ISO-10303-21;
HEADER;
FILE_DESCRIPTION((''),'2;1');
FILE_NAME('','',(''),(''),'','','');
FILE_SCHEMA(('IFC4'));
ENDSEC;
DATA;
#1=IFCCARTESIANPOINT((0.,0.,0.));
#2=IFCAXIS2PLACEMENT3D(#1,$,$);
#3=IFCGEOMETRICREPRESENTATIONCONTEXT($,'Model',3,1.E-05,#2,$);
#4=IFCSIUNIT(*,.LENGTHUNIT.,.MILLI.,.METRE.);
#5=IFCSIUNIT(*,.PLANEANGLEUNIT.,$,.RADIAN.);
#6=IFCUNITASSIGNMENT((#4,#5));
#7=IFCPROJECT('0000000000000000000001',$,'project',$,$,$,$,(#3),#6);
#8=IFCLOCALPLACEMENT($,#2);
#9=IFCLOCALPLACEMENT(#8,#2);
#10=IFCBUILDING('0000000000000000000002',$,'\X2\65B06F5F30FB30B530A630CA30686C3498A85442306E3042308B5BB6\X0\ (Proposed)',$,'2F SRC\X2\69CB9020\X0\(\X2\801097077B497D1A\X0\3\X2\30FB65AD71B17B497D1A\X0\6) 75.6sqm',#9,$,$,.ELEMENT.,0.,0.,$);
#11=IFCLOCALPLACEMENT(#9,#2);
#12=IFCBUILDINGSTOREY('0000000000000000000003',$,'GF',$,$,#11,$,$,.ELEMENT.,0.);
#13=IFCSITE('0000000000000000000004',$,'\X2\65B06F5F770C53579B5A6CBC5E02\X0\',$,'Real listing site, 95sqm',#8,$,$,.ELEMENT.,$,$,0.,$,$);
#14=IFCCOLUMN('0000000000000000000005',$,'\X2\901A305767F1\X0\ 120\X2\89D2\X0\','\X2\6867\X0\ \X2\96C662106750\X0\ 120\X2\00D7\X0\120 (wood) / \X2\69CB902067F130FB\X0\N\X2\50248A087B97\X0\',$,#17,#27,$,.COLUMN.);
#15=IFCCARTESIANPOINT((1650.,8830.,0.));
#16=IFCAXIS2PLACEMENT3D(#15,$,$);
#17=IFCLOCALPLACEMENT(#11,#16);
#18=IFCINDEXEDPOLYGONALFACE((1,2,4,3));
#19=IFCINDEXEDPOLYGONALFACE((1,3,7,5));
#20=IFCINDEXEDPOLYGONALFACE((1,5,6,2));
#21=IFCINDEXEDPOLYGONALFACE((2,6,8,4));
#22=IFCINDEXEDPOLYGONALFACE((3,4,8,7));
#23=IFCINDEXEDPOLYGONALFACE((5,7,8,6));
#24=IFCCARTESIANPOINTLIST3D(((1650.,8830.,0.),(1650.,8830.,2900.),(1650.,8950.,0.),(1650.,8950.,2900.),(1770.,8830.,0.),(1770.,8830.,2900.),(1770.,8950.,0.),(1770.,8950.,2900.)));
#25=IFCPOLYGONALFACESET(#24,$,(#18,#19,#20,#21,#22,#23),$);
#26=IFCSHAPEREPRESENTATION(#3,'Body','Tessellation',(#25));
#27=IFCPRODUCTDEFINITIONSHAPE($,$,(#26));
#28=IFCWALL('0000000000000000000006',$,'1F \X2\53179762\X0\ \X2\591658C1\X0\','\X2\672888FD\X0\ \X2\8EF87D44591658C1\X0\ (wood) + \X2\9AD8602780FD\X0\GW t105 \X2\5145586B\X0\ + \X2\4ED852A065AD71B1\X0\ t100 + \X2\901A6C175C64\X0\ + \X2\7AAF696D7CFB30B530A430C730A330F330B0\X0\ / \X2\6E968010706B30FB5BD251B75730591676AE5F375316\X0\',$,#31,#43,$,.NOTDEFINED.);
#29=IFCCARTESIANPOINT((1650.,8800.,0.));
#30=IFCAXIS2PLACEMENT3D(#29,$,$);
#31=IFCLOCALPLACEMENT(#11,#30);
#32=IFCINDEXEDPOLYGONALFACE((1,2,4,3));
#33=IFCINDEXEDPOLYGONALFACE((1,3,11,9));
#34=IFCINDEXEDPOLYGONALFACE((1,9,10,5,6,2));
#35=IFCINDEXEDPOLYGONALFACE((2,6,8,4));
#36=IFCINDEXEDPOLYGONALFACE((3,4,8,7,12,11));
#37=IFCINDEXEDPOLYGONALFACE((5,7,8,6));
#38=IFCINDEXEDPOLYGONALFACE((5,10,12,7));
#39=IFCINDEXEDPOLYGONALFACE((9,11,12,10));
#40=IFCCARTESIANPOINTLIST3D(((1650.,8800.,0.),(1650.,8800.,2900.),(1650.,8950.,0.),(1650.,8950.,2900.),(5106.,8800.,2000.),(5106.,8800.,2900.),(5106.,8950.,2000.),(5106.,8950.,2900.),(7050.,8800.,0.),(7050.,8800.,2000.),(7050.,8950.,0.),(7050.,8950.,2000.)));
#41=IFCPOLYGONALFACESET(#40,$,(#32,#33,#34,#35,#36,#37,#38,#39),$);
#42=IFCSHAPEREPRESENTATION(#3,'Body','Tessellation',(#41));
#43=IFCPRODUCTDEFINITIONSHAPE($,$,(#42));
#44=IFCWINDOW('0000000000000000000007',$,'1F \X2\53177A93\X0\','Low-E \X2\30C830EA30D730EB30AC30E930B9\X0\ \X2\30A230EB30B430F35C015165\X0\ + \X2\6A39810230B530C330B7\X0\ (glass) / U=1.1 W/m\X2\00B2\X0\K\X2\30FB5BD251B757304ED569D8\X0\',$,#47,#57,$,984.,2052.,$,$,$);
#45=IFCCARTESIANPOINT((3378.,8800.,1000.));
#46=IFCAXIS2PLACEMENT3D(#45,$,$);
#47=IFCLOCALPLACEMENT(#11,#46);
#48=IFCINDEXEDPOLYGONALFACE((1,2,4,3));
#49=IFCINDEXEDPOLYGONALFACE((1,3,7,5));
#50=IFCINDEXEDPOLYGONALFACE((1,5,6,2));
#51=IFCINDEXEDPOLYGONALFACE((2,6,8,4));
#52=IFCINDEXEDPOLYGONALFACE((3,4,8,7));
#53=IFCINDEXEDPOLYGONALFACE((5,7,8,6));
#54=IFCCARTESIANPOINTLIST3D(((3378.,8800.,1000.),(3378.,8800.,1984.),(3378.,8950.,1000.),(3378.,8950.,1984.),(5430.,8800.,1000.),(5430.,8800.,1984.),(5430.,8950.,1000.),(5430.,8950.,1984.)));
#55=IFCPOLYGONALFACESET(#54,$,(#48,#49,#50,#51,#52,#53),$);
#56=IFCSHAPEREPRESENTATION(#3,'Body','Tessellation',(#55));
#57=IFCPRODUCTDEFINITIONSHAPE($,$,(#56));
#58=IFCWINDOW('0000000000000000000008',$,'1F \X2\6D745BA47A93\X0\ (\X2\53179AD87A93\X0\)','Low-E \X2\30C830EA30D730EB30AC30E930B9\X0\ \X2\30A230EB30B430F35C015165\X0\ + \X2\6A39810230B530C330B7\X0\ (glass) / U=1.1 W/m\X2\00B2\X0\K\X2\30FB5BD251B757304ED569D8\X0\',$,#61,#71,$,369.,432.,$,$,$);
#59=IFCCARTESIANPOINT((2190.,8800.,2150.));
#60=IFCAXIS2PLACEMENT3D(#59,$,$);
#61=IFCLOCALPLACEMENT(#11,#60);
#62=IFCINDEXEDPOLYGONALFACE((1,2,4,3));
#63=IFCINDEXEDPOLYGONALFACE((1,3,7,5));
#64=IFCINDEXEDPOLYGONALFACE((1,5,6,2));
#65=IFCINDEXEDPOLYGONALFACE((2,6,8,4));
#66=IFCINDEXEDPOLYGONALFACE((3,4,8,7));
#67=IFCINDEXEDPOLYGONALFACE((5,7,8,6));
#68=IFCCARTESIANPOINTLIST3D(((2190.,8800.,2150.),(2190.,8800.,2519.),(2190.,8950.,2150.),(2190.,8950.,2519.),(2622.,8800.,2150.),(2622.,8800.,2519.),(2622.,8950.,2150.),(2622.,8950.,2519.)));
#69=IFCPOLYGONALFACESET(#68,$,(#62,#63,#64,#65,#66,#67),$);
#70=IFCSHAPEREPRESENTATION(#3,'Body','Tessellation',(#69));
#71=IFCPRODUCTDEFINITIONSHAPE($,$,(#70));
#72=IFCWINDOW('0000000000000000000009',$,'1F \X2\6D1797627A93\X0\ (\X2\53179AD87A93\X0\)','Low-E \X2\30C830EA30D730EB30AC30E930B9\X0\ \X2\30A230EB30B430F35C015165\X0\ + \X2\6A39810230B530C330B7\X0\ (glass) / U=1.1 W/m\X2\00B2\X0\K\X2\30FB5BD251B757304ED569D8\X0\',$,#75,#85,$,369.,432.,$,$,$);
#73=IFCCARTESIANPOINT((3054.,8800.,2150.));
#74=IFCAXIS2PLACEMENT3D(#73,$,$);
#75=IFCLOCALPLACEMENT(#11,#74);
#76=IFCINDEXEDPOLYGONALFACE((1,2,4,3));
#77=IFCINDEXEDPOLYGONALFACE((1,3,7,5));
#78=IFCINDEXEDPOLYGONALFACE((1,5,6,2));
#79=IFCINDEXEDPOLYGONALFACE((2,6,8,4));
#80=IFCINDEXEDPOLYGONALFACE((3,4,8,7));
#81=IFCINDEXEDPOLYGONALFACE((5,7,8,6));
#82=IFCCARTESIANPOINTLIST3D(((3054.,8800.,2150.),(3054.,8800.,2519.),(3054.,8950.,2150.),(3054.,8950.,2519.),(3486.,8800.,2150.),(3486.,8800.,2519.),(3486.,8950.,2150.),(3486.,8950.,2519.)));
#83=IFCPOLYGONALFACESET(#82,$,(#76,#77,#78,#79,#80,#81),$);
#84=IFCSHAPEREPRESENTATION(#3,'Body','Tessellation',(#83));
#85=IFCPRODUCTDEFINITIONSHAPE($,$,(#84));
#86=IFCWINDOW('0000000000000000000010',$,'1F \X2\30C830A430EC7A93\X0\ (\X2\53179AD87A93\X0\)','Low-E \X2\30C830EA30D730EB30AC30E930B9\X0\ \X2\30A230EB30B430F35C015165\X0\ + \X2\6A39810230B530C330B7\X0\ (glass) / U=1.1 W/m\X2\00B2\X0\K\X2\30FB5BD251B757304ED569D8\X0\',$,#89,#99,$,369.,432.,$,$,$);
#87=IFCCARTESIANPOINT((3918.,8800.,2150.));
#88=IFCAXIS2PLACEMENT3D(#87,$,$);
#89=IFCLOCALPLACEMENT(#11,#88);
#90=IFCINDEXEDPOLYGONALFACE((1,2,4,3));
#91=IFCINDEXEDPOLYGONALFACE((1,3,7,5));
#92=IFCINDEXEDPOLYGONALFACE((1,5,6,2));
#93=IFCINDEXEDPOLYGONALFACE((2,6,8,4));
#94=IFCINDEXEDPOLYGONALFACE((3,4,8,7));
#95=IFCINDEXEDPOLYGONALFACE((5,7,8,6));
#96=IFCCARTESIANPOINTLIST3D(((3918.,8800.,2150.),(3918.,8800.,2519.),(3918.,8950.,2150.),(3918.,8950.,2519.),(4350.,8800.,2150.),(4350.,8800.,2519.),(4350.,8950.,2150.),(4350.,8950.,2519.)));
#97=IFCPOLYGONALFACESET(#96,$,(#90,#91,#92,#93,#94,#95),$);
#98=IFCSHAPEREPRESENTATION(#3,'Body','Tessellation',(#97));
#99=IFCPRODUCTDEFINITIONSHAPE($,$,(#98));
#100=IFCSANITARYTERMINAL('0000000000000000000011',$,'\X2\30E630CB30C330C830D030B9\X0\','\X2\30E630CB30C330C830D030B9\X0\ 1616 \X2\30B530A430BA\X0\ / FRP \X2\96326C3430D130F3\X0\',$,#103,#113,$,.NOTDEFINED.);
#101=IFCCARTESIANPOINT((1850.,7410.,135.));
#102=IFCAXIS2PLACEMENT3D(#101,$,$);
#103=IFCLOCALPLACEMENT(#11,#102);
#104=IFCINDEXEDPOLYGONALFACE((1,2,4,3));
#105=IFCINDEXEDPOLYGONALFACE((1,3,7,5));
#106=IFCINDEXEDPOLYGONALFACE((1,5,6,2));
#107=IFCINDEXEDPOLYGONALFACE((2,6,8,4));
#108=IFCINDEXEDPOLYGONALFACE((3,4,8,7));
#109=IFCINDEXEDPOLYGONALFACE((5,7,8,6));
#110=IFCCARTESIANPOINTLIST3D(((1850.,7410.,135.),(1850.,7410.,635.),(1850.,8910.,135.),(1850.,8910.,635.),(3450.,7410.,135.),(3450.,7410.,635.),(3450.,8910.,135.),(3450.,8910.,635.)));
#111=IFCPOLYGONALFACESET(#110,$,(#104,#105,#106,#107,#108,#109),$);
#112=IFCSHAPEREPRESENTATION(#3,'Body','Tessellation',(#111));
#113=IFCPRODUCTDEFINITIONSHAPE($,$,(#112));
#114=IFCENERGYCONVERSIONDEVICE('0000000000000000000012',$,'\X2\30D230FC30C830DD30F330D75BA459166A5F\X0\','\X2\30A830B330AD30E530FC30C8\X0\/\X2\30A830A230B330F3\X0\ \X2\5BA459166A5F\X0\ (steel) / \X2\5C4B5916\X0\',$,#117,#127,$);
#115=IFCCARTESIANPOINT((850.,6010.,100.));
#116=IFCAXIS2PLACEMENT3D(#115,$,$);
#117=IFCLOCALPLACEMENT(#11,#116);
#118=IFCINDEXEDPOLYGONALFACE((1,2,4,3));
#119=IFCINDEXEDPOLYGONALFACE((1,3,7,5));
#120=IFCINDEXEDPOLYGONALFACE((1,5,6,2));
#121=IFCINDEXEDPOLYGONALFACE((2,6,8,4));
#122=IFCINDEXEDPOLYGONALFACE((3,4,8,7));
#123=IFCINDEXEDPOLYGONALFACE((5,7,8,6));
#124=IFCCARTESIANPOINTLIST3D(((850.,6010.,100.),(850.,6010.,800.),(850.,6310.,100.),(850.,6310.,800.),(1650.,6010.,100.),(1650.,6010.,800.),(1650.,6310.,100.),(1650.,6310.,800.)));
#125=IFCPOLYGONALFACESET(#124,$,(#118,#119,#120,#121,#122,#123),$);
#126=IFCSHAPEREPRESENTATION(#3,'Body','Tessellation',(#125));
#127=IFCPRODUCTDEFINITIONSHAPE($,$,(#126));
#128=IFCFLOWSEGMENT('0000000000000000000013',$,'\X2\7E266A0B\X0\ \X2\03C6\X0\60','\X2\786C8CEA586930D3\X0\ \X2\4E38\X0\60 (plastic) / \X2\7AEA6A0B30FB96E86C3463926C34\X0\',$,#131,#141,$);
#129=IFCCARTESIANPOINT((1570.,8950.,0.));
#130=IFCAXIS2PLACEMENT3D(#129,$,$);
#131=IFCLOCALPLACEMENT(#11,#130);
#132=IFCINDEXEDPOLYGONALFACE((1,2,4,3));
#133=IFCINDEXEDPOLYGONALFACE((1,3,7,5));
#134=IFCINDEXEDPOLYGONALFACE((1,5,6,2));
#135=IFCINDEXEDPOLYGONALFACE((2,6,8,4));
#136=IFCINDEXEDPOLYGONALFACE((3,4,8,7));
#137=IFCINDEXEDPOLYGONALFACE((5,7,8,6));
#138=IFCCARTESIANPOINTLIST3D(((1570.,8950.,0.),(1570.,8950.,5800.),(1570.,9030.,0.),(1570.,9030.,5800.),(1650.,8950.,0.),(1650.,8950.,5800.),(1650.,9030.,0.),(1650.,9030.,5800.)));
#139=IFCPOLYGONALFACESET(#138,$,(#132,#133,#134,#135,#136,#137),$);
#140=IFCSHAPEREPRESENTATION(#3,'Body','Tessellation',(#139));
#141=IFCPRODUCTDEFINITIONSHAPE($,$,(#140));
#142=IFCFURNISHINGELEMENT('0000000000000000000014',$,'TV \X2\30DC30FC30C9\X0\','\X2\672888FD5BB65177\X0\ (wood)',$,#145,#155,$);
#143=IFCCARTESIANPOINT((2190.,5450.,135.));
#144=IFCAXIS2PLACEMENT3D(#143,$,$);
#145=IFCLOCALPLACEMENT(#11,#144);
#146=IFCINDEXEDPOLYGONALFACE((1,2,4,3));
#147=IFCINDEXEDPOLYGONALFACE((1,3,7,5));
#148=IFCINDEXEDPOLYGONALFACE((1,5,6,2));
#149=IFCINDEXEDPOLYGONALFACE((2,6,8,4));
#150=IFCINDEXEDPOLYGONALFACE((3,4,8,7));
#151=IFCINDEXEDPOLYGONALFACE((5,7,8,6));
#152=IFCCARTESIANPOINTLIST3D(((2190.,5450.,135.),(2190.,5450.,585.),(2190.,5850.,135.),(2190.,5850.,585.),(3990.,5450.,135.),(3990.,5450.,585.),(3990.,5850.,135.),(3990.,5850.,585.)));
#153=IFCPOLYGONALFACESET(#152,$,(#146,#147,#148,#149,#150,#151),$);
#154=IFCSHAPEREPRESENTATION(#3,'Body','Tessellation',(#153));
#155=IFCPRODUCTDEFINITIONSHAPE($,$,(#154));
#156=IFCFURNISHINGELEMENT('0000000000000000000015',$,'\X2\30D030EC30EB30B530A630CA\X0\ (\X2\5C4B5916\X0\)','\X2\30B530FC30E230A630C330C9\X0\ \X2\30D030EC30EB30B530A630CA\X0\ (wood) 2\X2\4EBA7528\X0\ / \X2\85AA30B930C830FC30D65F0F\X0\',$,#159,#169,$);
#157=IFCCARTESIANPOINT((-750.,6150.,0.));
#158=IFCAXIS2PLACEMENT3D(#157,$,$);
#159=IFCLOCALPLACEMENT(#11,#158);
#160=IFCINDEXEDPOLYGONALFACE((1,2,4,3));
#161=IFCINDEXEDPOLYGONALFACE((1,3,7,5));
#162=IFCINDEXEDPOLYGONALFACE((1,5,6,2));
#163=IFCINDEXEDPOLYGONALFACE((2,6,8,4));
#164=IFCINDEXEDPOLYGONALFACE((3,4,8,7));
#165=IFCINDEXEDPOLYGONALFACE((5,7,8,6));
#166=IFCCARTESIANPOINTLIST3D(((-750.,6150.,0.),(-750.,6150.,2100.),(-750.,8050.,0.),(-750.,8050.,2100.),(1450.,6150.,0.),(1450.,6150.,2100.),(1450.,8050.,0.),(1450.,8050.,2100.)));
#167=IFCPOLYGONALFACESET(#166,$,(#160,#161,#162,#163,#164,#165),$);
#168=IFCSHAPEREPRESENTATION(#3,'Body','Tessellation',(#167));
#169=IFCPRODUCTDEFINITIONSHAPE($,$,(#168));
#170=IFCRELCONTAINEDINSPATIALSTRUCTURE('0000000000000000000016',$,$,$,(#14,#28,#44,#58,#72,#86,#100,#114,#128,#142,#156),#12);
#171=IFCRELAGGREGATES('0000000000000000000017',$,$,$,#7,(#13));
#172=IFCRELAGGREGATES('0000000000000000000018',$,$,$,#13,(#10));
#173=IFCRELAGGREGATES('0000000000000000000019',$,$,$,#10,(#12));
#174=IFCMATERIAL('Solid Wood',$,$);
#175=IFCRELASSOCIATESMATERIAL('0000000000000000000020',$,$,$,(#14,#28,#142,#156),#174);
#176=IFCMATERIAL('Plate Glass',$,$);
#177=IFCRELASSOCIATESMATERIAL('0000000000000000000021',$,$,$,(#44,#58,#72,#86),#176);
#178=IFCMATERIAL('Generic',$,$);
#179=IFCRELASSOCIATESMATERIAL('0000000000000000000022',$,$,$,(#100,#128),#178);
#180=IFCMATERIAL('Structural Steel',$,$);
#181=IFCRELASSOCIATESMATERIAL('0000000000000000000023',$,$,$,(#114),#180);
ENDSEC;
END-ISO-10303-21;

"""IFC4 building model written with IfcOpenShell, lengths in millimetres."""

from ifc_helpers import new_model, si_unit, frame, frame_2d, origin, place, context, project, spatial, rectangle, extrude, material, element, fill, save


model = new_model("IFC4")

# Units and contexts
model_context = context("Model", 3, precision=1e-05, world=origin())
ifc_project = project(units=[si_unit("LENGTHUNIT", "METRE", prefix="MILLI"), si_unit("PLANEANGLEUNIT", "RADIAN")], contexts=[model_context])

# Site, building, storey
site_placement = place(None, origin())
site = spatial("IfcSite", under=ifc_project, at=site_placement, Name="新潟県南魚沼市", ObjectType="Real listing site, 95sqm", CompositionType="ELEMENT", RefElevation=0.0)
building_placement = place(site_placement, origin())
building = spatial("IfcBuilding", under=site, at=building_placement, Name="新潟・サウナと水風呂のある家 (Proposed)", ObjectType="2F SRC構造(耐震等級3・断熱等級6) 75.6sqm", CompositionType="ELEMENT", ElevationOfRefHeight=0.0, ElevationOfTerrain=0.0)
storey_placement = place(building_placement, origin())
storey = spatial("IfcBuildingStorey", under=building, at=storey_placement, Name="GF", CompositionType="ELEMENT", Elevation=0.0)

# Column
ifc_material_1 = material(Name="Solid Wood")
column_1_placement = place(storey_placement, frame((1650.0, 8830.0, 0.0)))
element("IfcColumn", 1, at=column_1_placement, inside=storey, material=ifc_material_1, Name="通し柱 120角", Description="桧 集成材 120×120 (wood) / 構造柱・N値計算", PredefinedType="COLUMN", context=model_context, shape_type="SweptSolid", body=[
    extrude(rectangle(XDim=120.0, YDim=120.0, at=frame_2d((60.0, 60.0))), frame((1650.0, 8830.0, 0.0)), (0.0, 0.0, 1.0), 2900.0),
])

# Wall, openings, windows
wall_1_placement = place(storey_placement, frame((1650.0, 8800.0, 0.0)))
wall_1 = element("IfcWall", 2, at=wall_1_placement, inside=storey, material=ifc_material_1, Name="1F 北面 外壁", Description="木製 軸組外壁 (wood) + 高性能GW t105 充填 + 付加断熱 t100 + 通気層 + 窯業系サイディング / 準耐火・寒冷地外皮強化", PredefinedType="NOTDEFINED", context=model_context, shape_type="SweptSolid", body=[
    extrude(rectangle(XDim=5400.0, YDim=150.0, at=frame_2d((2700.0, 75.0))), frame((1650.0, 8800.0, 0.0)), (0.0, 0.0, 1.0), 2900.0),
])
opening_1_placement = place(storey_placement, frame((3378.0, 8800.0, 1000.0)))
opening_1 = element("IfcOpeningElement", 3, at=opening_1_placement, cuts=wall_1, PredefinedType="NOTDEFINED", context=model_context, shape_type="SweptSolid", body=[
    extrude(rectangle(XDim=2052.0, YDim=150.0, at=frame_2d((1026.0, 75.0))), frame((3378.0, 8800.0, 1000.0)), (0.0, 0.0, 1.0), 984.0),
])
opening_2_placement = place(storey_placement, frame((2190.0, 8800.0, 2150.0)))
opening_2 = element("IfcOpeningElement", 4, at=opening_2_placement, cuts=wall_1, PredefinedType="NOTDEFINED", context=model_context, shape_type="SweptSolid", body=[
    extrude(rectangle(XDim=432.0, YDim=150.0, at=frame_2d((216.0, 75.0))), frame((2190.0, 8800.0, 2150.0)), (0.0, 0.0, 1.0), 369.0),
])
opening_3_placement = place(storey_placement, frame((3054.0, 8800.0, 2150.0)))
opening_3 = element("IfcOpeningElement", 5, at=opening_3_placement, cuts=wall_1, PredefinedType="NOTDEFINED", context=model_context, shape_type="SweptSolid", body=[
    extrude(rectangle(XDim=432.0, YDim=150.0, at=frame_2d((216.0, 75.0))), frame((3054.0, 8800.0, 2150.0)), (0.0, 0.0, 1.0), 369.0),
])
opening_4_placement = place(storey_placement, frame((3918.0, 8800.0, 2150.0)))
opening_4 = element("IfcOpeningElement", 6, at=opening_4_placement, cuts=wall_1, PredefinedType="NOTDEFINED", context=model_context, shape_type="SweptSolid", body=[
    extrude(rectangle(XDim=432.0, YDim=150.0, at=frame_2d((216.0, 75.0))), frame((3918.0, 8800.0, 2150.0)), (0.0, 0.0, 1.0), 369.0),
])
ifc_material_2 = material(Name="Plate Glass")
window_1_placement = place(storey_placement, frame((3378.0, 8800.0, 1000.0)))
window_1 = element("IfcWindow", 7, at=window_1_placement, inside=storey, material=ifc_material_2, Name="1F 北窓", Description="Low-E トリプルガラス アルゴン封入 + 樹脂サッシ (glass) / U=1.1 W/m²K・寒冷地仕様", OverallHeight=984.0, OverallWidth=2052.0, context=model_context, shape_type="SweptSolid", body=[
    extrude(rectangle(XDim=2052.0, YDim=150.0, at=frame_2d((1026.0, 75.0))), frame((3378.0, 8800.0, 1000.0)), (0.0, 0.0, 1.0), 984.0),
])
fill(opening_1, window_1)
window_2_placement = place(storey_placement, frame((2190.0, 8800.0, 2150.0)))
window_2 = element("IfcWindow", 8, at=window_2_placement, inside=storey, material=ifc_material_2, Name="1F 浴室窓 (北高窓)", Description="Low-E トリプルガラス アルゴン封入 + 樹脂サッシ (glass) / U=1.1 W/m²K・寒冷地仕様", OverallHeight=369.0, OverallWidth=432.0, context=model_context, shape_type="SweptSolid", body=[
    extrude(rectangle(XDim=432.0, YDim=150.0, at=frame_2d((216.0, 75.0))), frame((2190.0, 8800.0, 2150.0)), (0.0, 0.0, 1.0), 369.0),
])
fill(opening_2, window_2)
window_3_placement = place(storey_placement, frame((3054.0, 8800.0, 2150.0)))
window_3 = element("IfcWindow", 9, at=window_3_placement, inside=storey, material=ifc_material_2, Name="1F 洗面窓 (北高窓)", Description="Low-E トリプルガラス アルゴン封入 + 樹脂サッシ (glass) / U=1.1 W/m²K・寒冷地仕様", OverallHeight=369.0, OverallWidth=432.0, context=model_context, shape_type="SweptSolid", body=[
    extrude(rectangle(XDim=432.0, YDim=150.0, at=frame_2d((216.0, 75.0))), frame((3054.0, 8800.0, 2150.0)), (0.0, 0.0, 1.0), 369.0),
])
fill(opening_3, window_3)
window_4_placement = place(storey_placement, frame((3918.0, 8800.0, 2150.0)))
window_4 = element("IfcWindow", 10, at=window_4_placement, inside=storey, material=ifc_material_2, Name="1F トイレ窓 (北高窓)", Description="Low-E トリプルガラス アルゴン封入 + 樹脂サッシ (glass) / U=1.1 W/m²K・寒冷地仕様", OverallHeight=369.0, OverallWidth=432.0, context=model_context, shape_type="SweptSolid", body=[
    extrude(rectangle(XDim=432.0, YDim=150.0, at=frame_2d((216.0, 75.0))), frame((3918.0, 8800.0, 2150.0)), (0.0, 0.0, 1.0), 369.0),
])
fill(opening_4, window_4)

# Sanitary terminal
ifc_material_3 = material(Name="Generic")
sanitary_terminal_placement = place(storey_placement, frame((1850.0, 7410.0, 135.0)))
element("IfcSanitaryTerminal", 11, at=sanitary_terminal_placement, inside=storey, material=ifc_material_3, Name="ユニットバス", Description="ユニットバス 1616 サイズ / FRP 防水パン", PredefinedType="NOTDEFINED", context=model_context, shape_type="SweptSolid", body=[
    extrude(rectangle(XDim=1600.0, YDim=1500.0, at=frame_2d((800.0, 750.0))), frame((1850.0, 7410.0, 135.0)), (0.0, 0.0, 1.0), 500.0),
])

# Shared definitions
ifc_material_4 = material(Name="Structural Steel")

# Energy conversion device
energy_conversion_device_placement = place(storey_placement, frame((850.0, 6010.0, 100.0)))
element("IfcEnergyConversionDevice", 12, at=energy_conversion_device_placement, inside=storey, material=ifc_material_4, Name="ヒートポンプ室外機", Description="エコキュート/エアコン 室外機 (steel) / 屋外", context=model_context, shape_type="SweptSolid", body=[
    extrude(rectangle(XDim=800.0, YDim=300.0, at=frame_2d((400.0, 150.0))), frame((850.0, 6010.0, 100.0)), (0.0, 0.0, 1.0), 700.0),
])

# Flow segment
flow_segment_placement = place(storey_placement, frame((1570.0, 8950.0, 0.0)))
element("IfcFlowSegment", 13, at=flow_segment_placement, inside=storey, material=ifc_material_3, Name="縦樋 φ60", Description="硬質塩ビ 丸60 (plastic) / 竪樋・雨水排水", context=model_context, shape_type="SweptSolid", body=[
    extrude(rectangle(XDim=80.0, YDim=80.0, at=frame_2d((40.0, 40.0))), frame((1570.0, 8950.0, 0.0)), (0.0, 0.0, 1.0), 5800.0),
])

# Furnishing elements
furnishing_1_placement = place(storey_placement, frame((2190.0, 5450.0, 135.0)))
element("IfcFurnishingElement", 14, at=furnishing_1_placement, inside=storey, material=ifc_material_1, Name="TV ボード", Description="木製家具 (wood)", context=model_context, shape_type="SweptSolid", body=[
    extrude(rectangle(XDim=1800.0, YDim=400.0, at=frame_2d((900.0, 200.0))), frame((2190.0, 5450.0, 135.0)), (0.0, 0.0, 1.0), 450.0),
])
furnishing_2_placement = place(storey_placement, frame((-750.0, 6150.0, 0.0)))
element("IfcFurnishingElement", 15, at=furnishing_2_placement, inside=storey, material=ifc_material_1, Name="バレルサウナ (屋外)", Description="サーモウッド バレルサウナ (wood) 2人用 / 薪ストーブ式", context=model_context, shape_type="SweptSolid", body=[
    extrude(rectangle(XDim=2200.0, YDim=1900.0, at=frame_2d((1100.0, 950.0))), frame((-750.0, 6150.0, 0.0)), (0.0, 0.0, 1.0), 2100.0),
])

save(model, "model.ifc")
